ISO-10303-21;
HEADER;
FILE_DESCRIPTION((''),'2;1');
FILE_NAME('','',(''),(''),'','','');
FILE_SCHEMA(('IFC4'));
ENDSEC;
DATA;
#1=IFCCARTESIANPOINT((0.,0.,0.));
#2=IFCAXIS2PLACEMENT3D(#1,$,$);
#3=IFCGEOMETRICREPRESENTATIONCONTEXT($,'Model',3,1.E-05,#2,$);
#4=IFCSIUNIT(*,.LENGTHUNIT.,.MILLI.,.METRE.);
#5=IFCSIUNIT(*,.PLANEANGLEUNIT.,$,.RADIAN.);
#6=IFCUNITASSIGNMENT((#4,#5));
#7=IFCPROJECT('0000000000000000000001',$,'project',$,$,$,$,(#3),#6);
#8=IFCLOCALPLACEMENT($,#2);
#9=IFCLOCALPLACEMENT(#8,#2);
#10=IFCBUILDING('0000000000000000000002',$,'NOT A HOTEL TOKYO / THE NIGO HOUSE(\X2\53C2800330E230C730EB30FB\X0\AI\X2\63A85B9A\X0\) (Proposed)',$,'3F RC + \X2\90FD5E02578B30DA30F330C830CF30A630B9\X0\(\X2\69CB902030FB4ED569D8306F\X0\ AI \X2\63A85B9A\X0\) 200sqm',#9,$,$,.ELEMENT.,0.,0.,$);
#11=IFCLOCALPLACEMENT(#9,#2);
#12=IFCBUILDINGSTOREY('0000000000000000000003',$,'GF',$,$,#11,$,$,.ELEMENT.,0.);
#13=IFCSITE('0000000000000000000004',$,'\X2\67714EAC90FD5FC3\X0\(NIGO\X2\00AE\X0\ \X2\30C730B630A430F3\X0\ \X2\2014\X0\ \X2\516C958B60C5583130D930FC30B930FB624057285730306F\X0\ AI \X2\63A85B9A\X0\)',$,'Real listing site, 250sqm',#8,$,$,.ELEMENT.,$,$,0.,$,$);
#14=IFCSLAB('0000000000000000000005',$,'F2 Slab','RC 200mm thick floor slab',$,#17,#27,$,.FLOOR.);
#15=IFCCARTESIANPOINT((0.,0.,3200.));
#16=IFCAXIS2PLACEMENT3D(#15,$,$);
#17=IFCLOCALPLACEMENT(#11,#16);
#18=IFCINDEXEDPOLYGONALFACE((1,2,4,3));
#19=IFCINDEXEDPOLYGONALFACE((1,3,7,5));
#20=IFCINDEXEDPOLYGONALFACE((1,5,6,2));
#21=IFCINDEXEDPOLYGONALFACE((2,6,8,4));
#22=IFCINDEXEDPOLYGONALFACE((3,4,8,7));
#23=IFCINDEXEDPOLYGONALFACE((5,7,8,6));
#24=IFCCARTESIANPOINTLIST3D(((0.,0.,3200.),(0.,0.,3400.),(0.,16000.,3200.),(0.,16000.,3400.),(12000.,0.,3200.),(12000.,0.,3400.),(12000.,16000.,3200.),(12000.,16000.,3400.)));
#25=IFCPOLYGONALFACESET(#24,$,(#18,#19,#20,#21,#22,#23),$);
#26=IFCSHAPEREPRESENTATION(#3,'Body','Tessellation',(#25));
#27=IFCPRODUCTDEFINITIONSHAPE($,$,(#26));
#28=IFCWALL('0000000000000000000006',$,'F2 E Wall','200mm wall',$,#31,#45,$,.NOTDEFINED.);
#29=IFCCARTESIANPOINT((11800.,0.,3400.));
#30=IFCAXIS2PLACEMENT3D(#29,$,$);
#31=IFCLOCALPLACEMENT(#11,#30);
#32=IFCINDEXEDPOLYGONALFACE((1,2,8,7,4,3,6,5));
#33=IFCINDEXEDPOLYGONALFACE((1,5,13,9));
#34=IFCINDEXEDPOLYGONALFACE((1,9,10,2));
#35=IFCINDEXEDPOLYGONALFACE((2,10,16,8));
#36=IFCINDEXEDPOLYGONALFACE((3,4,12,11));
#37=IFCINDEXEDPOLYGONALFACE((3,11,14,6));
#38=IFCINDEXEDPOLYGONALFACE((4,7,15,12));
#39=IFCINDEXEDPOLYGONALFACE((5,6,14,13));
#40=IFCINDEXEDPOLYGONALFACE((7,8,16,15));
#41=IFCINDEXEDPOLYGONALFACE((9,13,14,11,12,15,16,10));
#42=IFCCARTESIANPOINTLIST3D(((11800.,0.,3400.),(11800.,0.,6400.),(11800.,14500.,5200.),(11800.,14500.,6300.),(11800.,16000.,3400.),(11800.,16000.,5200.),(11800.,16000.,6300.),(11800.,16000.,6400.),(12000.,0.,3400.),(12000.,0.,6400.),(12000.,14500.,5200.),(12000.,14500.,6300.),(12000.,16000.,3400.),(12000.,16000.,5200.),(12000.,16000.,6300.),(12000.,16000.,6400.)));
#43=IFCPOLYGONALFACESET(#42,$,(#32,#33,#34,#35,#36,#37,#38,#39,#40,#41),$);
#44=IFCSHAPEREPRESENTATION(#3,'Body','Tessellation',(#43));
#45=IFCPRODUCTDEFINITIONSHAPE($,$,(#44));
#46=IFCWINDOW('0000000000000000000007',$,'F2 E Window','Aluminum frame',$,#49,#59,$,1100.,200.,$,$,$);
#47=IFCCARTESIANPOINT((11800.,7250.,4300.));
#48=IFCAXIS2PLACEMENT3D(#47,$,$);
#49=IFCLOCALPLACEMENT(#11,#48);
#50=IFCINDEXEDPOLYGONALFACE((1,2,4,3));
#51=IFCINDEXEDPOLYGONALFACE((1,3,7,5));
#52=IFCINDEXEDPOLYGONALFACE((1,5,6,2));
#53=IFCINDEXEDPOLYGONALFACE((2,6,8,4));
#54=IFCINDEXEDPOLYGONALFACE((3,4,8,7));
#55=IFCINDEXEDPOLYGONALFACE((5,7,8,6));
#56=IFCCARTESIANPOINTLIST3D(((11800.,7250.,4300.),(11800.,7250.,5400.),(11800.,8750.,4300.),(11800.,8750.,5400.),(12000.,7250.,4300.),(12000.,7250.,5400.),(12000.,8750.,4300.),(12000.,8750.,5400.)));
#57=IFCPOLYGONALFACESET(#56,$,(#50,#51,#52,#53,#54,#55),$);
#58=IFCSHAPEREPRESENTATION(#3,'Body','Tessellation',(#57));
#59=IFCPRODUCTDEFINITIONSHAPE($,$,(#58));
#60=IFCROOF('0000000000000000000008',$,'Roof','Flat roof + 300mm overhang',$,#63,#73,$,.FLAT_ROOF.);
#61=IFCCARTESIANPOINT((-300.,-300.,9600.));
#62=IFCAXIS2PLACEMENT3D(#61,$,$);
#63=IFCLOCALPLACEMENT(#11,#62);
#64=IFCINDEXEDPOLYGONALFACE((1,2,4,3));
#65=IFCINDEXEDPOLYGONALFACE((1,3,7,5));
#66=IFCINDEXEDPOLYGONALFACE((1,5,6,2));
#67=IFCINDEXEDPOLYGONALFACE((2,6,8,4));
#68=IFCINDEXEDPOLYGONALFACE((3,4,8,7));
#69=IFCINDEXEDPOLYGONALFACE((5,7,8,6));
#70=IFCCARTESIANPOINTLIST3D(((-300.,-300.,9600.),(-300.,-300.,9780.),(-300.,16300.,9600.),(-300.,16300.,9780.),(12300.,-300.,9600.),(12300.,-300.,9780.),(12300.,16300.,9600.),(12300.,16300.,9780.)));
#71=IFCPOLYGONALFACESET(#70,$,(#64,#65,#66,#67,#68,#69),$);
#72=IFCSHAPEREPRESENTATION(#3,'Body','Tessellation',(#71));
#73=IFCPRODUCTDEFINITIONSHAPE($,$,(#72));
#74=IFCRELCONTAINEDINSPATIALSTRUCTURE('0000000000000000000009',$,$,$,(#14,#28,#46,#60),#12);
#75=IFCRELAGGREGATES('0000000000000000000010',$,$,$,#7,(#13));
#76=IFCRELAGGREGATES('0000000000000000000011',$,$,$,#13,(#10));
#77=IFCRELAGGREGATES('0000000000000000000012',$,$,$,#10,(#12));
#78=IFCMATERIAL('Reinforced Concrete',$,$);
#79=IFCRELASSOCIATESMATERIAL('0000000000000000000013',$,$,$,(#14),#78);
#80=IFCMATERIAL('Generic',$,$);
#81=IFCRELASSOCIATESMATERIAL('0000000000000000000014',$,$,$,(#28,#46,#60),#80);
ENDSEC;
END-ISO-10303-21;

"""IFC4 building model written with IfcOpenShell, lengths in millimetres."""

from ifc_helpers import new_model, si_unit, frame, frame_2d, origin, place, context, project, spatial, rectangle, extrude, material, element, fill, save


model = new_model("IFC4")

# Units and contexts
model_context = context("Model", 3, precision=1e-05, world=origin())
ifc_project = project(units=[si_unit("LENGTHUNIT", "METRE", prefix="MILLI"), si_unit("PLANEANGLEUNIT", "RADIAN")], contexts=[model_context])

# Site, building, storey
site_placement = place(None, origin())
site = spatial("IfcSite", under=ifc_project, at=site_placement, Name="東京都心(NIGO® デザイン — 公開情報ベース・所在地は AI 推定)", ObjectType="Real listing site, 250sqm", CompositionType="ELEMENT", RefElevation=0.0)
building_placement = place(site_placement, origin())
building = spatial("IfcBuilding", under=site, at=building_placement, Name="NOT A HOTEL TOKYO / THE NIGO HOUSE(参考モデル・AI推定) (Proposed)", ObjectType="3F RC + 都市型ペントハウス(構造・仕様は AI 推定) 200sqm", CompositionType="ELEMENT", ElevationOfRefHeight=0.0, ElevationOfTerrain=0.0)
storey_placement = place(building_placement, origin())
storey = spatial("IfcBuildingStorey", under=building, at=storey_placement, Name="GF", CompositionType="ELEMENT", Elevation=0.0)

# Slab
ifc_material_1 = material(Name="Reinforced Concrete")
slab_1_placement = place(storey_placement, frame((0.0, 0.0, 3200.0)))
element("IfcSlab", 1, at=slab_1_placement, inside=storey, material=ifc_material_1, Name="F2 Slab", Description="RC 200mm thick floor slab", PredefinedType="FLOOR", context=model_context, shape_type="SweptSolid", body=[
    extrude(rectangle(XDim=12000.0, YDim=16000.0, at=frame_2d((6000.0, 8000.0))), frame((0.0, 0.0, 3200.0)), (0.0, 0.0, 1.0), 200.0),
])

# Shared definitions
ifc_material_2 = material(Name="Generic")

# Wall, opening, window
wall_1_placement = place(storey_placement, frame((11800.0, 0.0, 3400.0)))
wall_1 = element("IfcWall", 2, at=wall_1_placement, inside=storey, material=ifc_material_2, Name="F2 E Wall", Description="200mm wall", PredefinedType="NOTDEFINED", context=model_context, shape_type="SweptSolid", body=[
    extrude(rectangle(XDim=200.0, YDim=16000.0, at=frame_2d((100.0, 8000.0))), frame((11800.0, 0.0, 3400.0)), (0.0, 0.0, 1.0), 3000.0),
])
opening_1_placement = place(storey_placement, frame((11800.0, 7250.0, 4300.0)))
opening_1 = element("IfcOpeningElement", 3, at=opening_1_placement, cuts=wall_1, PredefinedType="NOTDEFINED", context=model_context, shape_type="SweptSolid", body=[
    extrude(rectangle(XDim=200.0, YDim=1500.0, at=frame_2d((100.0, 750.0))), frame((11800.0, 7250.0, 4300.0)), (0.0, 0.0, 1.0), 1100.0),
])
window_1_placement = place(storey_placement, frame((11800.0, 7250.0, 4300.0)))
window_1 = element("IfcWindow", 4, at=window_1_placement, inside=storey, material=ifc_material_2, Name="F2 E Window", Description="Aluminum frame", OverallHeight=1100.0, OverallWidth=200.0, context=model_context, shape_type="SweptSolid", body=[
    extrude(rectangle(XDim=200.0, YDim=1500.0, at=frame_2d((100.0, 750.0))), frame((11800.0, 7250.0, 4300.0)), (0.0, 0.0, 1.0), 1100.0),
])
fill(opening_1, window_1)

# Roof
roof_placement = place(storey_placement, frame((-300.0, -300.0, 9600.0)))
element("IfcRoof", 5, at=roof_placement, inside=storey, material=ifc_material_2, Name="Roof", Description="Flat roof + 300mm overhang", PredefinedType="FLAT_ROOF", context=model_context, shape_type="SweptSolid", body=[
    extrude(rectangle(XDim=12600.0, YDim=16600.0, at=frame_2d((6300.0, 8300.0))), frame((-300.0, -300.0, 9600.0)), (0.0, 0.0, 1.0), 180.0),
])

save(model, "model.ifc")
